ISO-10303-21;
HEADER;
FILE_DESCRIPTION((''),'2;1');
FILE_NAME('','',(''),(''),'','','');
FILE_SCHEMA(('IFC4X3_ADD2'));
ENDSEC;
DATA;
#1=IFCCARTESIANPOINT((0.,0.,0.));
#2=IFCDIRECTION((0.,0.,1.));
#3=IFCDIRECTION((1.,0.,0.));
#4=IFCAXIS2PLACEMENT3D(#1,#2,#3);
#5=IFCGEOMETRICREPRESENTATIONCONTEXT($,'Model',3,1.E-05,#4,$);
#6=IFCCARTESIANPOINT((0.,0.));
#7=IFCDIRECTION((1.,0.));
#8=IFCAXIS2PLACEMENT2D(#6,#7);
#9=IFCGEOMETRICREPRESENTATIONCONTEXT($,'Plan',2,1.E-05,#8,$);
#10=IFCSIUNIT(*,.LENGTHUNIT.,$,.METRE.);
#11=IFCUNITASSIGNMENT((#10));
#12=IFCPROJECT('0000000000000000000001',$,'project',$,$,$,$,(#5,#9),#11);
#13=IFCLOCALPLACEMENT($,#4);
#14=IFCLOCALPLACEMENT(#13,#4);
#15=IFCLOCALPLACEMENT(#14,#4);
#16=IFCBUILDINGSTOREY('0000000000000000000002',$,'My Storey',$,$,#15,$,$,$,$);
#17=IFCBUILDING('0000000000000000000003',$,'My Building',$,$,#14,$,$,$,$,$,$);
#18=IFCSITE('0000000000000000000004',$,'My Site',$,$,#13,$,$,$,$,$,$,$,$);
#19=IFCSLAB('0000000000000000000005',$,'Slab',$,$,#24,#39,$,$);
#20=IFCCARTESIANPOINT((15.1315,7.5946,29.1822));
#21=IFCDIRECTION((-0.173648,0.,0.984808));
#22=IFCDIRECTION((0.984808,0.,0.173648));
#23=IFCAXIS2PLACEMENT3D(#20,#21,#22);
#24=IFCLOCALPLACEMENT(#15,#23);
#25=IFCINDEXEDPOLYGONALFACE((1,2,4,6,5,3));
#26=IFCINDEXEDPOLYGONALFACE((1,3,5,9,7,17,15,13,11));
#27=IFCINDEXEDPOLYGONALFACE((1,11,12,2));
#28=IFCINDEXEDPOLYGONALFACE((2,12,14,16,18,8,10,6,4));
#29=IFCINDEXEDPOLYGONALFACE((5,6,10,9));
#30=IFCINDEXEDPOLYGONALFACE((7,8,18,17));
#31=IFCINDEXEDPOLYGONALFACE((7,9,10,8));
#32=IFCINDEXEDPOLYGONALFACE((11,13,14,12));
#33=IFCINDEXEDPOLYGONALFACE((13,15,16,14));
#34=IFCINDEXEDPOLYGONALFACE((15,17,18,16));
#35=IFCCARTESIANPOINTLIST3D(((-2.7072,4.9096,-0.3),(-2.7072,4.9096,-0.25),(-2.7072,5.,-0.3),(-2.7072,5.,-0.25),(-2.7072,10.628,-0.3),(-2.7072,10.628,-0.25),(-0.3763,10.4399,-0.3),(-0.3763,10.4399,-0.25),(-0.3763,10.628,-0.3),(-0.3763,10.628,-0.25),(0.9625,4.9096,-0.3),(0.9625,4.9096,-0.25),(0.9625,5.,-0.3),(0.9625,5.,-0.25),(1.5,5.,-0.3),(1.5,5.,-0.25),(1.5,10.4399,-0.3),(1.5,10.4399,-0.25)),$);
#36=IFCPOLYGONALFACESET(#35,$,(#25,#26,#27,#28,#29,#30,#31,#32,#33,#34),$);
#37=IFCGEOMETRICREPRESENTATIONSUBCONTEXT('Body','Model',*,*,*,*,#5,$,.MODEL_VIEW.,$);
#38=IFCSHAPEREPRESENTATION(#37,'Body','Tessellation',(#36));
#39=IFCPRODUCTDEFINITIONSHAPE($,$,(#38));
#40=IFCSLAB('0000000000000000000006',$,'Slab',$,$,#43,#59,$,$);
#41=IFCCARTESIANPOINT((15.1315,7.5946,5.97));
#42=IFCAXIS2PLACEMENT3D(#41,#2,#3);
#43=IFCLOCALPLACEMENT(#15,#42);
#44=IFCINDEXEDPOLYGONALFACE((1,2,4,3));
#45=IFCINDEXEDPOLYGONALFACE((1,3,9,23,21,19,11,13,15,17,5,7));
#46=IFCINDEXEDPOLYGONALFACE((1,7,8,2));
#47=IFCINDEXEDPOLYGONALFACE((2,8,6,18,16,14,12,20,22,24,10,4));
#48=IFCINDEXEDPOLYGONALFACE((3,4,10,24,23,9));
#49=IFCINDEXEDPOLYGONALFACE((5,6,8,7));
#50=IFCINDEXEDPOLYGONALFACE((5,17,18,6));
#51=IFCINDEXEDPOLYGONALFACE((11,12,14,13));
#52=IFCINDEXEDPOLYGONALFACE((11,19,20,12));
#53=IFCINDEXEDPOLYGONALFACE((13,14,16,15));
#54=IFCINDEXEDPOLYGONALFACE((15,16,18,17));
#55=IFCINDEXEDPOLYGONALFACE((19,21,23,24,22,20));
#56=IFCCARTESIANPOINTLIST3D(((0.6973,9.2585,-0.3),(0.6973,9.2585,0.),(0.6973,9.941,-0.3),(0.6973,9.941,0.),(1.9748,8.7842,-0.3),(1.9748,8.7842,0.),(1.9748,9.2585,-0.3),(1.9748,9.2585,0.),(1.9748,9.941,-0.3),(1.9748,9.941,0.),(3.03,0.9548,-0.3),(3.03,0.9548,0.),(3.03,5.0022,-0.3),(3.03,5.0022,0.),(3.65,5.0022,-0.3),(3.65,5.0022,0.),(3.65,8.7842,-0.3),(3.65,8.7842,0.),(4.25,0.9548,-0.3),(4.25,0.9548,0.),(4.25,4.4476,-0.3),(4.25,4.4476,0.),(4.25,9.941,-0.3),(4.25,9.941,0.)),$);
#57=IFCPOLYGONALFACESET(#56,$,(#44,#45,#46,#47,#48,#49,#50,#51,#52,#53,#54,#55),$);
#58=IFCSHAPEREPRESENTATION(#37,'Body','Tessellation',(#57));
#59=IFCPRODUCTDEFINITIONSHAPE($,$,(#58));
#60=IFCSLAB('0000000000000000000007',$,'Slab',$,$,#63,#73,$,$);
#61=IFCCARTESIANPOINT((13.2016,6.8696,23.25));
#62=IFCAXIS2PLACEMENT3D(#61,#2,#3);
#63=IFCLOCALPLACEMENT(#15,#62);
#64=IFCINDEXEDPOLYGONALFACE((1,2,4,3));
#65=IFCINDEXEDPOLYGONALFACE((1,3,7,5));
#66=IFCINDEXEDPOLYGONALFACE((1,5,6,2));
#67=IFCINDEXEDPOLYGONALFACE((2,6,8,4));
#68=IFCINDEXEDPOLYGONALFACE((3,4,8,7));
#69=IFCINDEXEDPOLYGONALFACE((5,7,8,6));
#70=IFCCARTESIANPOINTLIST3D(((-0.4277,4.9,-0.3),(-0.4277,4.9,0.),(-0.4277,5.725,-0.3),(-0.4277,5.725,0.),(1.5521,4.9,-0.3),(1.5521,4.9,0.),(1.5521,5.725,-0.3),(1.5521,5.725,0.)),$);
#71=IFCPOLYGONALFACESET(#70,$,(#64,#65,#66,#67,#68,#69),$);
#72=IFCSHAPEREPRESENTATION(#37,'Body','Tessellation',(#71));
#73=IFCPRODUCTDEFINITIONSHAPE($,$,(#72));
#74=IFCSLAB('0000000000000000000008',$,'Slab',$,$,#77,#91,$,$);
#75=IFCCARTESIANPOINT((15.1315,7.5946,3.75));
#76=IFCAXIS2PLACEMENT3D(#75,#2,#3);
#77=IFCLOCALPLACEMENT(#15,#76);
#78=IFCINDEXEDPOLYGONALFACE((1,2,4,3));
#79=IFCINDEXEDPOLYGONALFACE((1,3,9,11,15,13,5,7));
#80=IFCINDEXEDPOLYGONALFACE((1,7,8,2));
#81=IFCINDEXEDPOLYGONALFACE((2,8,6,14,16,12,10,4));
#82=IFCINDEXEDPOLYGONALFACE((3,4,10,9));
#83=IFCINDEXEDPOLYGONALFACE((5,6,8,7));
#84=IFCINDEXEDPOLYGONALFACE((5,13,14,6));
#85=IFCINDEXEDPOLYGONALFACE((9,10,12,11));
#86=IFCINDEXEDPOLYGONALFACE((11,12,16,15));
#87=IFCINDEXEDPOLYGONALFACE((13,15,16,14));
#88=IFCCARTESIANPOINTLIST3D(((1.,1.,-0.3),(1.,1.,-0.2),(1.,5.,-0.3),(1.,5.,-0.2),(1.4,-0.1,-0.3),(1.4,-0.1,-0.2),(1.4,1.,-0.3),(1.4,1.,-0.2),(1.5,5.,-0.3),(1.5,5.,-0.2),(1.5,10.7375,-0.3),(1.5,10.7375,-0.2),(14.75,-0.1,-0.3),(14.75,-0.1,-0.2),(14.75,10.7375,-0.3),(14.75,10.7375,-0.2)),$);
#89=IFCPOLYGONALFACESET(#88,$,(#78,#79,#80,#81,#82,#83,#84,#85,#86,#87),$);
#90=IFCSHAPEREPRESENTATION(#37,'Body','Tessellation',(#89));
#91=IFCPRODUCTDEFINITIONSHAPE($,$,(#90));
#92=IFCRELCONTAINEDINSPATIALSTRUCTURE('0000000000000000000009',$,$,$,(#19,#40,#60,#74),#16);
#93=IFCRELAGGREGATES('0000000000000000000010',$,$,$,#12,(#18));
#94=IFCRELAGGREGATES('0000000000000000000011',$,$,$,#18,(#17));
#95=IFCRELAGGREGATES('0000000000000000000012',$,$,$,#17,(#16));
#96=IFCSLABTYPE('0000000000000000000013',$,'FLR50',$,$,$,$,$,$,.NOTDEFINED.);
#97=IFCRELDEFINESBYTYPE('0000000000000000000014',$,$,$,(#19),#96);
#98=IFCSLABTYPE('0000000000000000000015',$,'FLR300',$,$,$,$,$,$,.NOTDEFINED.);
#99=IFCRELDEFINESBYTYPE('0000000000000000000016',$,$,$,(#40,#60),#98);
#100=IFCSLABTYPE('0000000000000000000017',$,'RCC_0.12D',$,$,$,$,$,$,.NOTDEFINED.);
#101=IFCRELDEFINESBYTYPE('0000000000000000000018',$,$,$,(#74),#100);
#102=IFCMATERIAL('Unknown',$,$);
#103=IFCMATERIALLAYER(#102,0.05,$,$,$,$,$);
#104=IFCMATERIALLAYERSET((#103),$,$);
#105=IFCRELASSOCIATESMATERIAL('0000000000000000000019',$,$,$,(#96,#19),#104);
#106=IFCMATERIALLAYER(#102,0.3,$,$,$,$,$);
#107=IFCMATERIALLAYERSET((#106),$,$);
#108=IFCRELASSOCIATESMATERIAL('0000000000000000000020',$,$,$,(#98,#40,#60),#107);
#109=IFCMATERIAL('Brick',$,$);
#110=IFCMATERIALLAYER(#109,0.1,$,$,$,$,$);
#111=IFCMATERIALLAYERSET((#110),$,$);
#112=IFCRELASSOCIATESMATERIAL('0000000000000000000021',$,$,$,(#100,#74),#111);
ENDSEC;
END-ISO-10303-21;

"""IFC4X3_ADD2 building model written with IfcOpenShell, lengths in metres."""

from ifc_helpers import new_model, si_unit, frame, origin_with_axes, origin_2d_with_axis, place, context, subcontext, project, spatial, indexed_curve, outline, extrude, material, layer, layer_set, layer_usage, type_object, element, save


model = new_model("IFC4X3_ADD2")

# Units and contexts
model_context = context("Model", 3, precision=1e-05, world=origin_with_axes())
plan_context = context("Plan", 2, precision=1e-05, world=origin_2d_with_axis())
body_context = subcontext(model_context, "Body", "Model", "MODEL_VIEW")
ifc_project = project(units=[si_unit("LENGTHUNIT", "METRE")], contexts=[model_context, plan_context])

# Site, building, storey
site_placement = place(None, origin_with_axes())
site = spatial("IfcSite", under=ifc_project, at=site_placement, Name="My Site")
building_placement = place(site_placement, origin_with_axes())
building = spatial("IfcBuilding", under=site, at=building_placement, Name="My Building")
storey_placement = place(building_placement, origin_with_axes())
storey = spatial("IfcBuildingStorey", under=building, at=storey_placement, Name="My Storey")

# Slabs
ifc_material_1 = material(Name="Unknown")
ifc_layer_1 = layer(ifc_material_1, 0.05)
ifc_layer_set_1 = layer_set([ifc_layer_1])
ifc_layer_usage_1 = layer_usage(ifc_layer_set_1, "AXIS3", "POSITIVE", -0.3)
slab_type_1 = type_object("IfcSlabType", Name="FLR50", PredefinedType="NOTDEFINED", material=ifc_layer_set_1)
slab_1_placement = place(storey_placement, frame((15.1315, 7.5946, 29.1822), z_axis=(-0.173648, 0.0, 0.984808), x_axis=(0.984808, 0.0, 0.173648)))
element("IfcSlab", 1, at=slab_1_placement, inside=storey, type_object=slab_type_1, material=ifc_layer_usage_1, Name="Slab", context=body_context, shape_type="SweptSolid", body=[
    extrude(outline(indexed_curve([(-0.3763, 10.4399), (-0.3763, 10.628), (-2.7072, 10.628), (-2.7072, 5.0), (-2.7072, 4.9096), (0.9625, 4.9096), (0.9625, 5.0), (1.5, 5.0), (1.5, 10.4399), (-0.3763, 10.4399)])), frame((0.0, 0.0, -0.3), z_axis=(0.0, 0.0, 1.0), x_axis=(1.0, 0.0, 0.0)), (0.0, 0.0, 1.0), 0.05),
])
ifc_layer_2 = layer(ifc_material_1, 0.3)
ifc_layer_set_2 = layer_set([ifc_layer_2])
ifc_layer_usage_2 = layer_usage(ifc_layer_set_2, "AXIS3", "POSITIVE", -0.3)
slab_type_2 = type_object("IfcSlabType", Name="FLR300", PredefinedType="NOTDEFINED", material=ifc_layer_set_2)
slab_2_placement = place(storey_placement, frame((15.1315, 7.5946, 5.97), z_axis=(0.0, 0.0, 1.0), x_axis=(1.0, 0.0, 0.0)))
element("IfcSlab", 2, at=slab_2_placement, inside=storey, type_object=slab_type_2, material=ifc_layer_usage_2, Name="Slab", context=body_context, shape_type="SweptSolid", body=[
    extrude(outline(indexed_curve([(3.03, 0.9548), (4.25, 0.9548), (4.25, 4.4476), (4.25, 9.941), (1.9748, 9.941), (0.6973, 9.941), (0.6973, 9.2585), (1.9748, 9.2585), (1.9748, 8.7842), (3.65, 8.7842), (3.65, 5.0022), (3.03, 5.0022), (3.03, 0.9548)])), frame((0.0, 0.0, -0.3), z_axis=(0.0, 0.0, 1.0), x_axis=(1.0, 0.0, 0.0)), (0.0, 0.0, 1.0), 0.3),
])
ifc_layer_usage_3 = layer_usage(ifc_layer_set_2, "AXIS3", "POSITIVE", -0.3)
slab_3_placement = place(storey_placement, frame((13.2016, 6.8696, 23.25), z_axis=(0.0, 0.0, 1.0), x_axis=(1.0, 0.0, 0.0)))
element("IfcSlab", 3, at=slab_3_placement, inside=storey, type_object=slab_type_2, material=ifc_layer_usage_3, Name="Slab", context=body_context, shape_type="SweptSolid", body=[
    extrude(outline(indexed_curve([(-0.4277, 5.725), (-0.4277, 4.9), (1.5521, 4.9), (1.5521, 5.725), (-0.4277, 5.725)])), frame((0.0, 0.0, -0.3), z_axis=(0.0, 0.0, 1.0), x_axis=(1.0, 0.0, 0.0)), (0.0, 0.0, 1.0), 0.3),
])
ifc_material_2 = material(Name="Brick")
ifc_layer_3 = layer(ifc_material_2, 0.1)
ifc_layer_set_3 = layer_set([ifc_layer_3])
ifc_layer_usage_4 = layer_usage(ifc_layer_set_3, "AXIS3", "POSITIVE", -0.3)
slab_type_3 = type_object("IfcSlabType", Name="RCC_0.12D", PredefinedType="NOTDEFINED", material=ifc_layer_set_3)
slab_4_placement = place(storey_placement, frame((15.1315, 7.5946, 3.75), z_axis=(0.0, 0.0, 1.0), x_axis=(1.0, 0.0, 0.0)))
element("IfcSlab", 4, at=slab_4_placement, inside=storey, type_object=slab_type_3, material=ifc_layer_usage_4, Name="Slab", context=body_context, shape_type="SweptSolid", body=[
    extrude(outline(indexed_curve([(1.4, 1.0), (1.0, 1.0), (1.0, 5.0), (1.5, 5.0), (1.5, 10.7375), (14.75, 10.7375), (14.75, -0.1), (1.4, -0.1), (1.4, 1.0)])), frame((0.0, 0.0, -0.3), z_axis=(0.0, 0.0, 1.0), x_axis=(1.0, 0.0, 0.0)), (0.0, 0.0, 1.0), 0.1),
])

save(model, "model.ifc")
